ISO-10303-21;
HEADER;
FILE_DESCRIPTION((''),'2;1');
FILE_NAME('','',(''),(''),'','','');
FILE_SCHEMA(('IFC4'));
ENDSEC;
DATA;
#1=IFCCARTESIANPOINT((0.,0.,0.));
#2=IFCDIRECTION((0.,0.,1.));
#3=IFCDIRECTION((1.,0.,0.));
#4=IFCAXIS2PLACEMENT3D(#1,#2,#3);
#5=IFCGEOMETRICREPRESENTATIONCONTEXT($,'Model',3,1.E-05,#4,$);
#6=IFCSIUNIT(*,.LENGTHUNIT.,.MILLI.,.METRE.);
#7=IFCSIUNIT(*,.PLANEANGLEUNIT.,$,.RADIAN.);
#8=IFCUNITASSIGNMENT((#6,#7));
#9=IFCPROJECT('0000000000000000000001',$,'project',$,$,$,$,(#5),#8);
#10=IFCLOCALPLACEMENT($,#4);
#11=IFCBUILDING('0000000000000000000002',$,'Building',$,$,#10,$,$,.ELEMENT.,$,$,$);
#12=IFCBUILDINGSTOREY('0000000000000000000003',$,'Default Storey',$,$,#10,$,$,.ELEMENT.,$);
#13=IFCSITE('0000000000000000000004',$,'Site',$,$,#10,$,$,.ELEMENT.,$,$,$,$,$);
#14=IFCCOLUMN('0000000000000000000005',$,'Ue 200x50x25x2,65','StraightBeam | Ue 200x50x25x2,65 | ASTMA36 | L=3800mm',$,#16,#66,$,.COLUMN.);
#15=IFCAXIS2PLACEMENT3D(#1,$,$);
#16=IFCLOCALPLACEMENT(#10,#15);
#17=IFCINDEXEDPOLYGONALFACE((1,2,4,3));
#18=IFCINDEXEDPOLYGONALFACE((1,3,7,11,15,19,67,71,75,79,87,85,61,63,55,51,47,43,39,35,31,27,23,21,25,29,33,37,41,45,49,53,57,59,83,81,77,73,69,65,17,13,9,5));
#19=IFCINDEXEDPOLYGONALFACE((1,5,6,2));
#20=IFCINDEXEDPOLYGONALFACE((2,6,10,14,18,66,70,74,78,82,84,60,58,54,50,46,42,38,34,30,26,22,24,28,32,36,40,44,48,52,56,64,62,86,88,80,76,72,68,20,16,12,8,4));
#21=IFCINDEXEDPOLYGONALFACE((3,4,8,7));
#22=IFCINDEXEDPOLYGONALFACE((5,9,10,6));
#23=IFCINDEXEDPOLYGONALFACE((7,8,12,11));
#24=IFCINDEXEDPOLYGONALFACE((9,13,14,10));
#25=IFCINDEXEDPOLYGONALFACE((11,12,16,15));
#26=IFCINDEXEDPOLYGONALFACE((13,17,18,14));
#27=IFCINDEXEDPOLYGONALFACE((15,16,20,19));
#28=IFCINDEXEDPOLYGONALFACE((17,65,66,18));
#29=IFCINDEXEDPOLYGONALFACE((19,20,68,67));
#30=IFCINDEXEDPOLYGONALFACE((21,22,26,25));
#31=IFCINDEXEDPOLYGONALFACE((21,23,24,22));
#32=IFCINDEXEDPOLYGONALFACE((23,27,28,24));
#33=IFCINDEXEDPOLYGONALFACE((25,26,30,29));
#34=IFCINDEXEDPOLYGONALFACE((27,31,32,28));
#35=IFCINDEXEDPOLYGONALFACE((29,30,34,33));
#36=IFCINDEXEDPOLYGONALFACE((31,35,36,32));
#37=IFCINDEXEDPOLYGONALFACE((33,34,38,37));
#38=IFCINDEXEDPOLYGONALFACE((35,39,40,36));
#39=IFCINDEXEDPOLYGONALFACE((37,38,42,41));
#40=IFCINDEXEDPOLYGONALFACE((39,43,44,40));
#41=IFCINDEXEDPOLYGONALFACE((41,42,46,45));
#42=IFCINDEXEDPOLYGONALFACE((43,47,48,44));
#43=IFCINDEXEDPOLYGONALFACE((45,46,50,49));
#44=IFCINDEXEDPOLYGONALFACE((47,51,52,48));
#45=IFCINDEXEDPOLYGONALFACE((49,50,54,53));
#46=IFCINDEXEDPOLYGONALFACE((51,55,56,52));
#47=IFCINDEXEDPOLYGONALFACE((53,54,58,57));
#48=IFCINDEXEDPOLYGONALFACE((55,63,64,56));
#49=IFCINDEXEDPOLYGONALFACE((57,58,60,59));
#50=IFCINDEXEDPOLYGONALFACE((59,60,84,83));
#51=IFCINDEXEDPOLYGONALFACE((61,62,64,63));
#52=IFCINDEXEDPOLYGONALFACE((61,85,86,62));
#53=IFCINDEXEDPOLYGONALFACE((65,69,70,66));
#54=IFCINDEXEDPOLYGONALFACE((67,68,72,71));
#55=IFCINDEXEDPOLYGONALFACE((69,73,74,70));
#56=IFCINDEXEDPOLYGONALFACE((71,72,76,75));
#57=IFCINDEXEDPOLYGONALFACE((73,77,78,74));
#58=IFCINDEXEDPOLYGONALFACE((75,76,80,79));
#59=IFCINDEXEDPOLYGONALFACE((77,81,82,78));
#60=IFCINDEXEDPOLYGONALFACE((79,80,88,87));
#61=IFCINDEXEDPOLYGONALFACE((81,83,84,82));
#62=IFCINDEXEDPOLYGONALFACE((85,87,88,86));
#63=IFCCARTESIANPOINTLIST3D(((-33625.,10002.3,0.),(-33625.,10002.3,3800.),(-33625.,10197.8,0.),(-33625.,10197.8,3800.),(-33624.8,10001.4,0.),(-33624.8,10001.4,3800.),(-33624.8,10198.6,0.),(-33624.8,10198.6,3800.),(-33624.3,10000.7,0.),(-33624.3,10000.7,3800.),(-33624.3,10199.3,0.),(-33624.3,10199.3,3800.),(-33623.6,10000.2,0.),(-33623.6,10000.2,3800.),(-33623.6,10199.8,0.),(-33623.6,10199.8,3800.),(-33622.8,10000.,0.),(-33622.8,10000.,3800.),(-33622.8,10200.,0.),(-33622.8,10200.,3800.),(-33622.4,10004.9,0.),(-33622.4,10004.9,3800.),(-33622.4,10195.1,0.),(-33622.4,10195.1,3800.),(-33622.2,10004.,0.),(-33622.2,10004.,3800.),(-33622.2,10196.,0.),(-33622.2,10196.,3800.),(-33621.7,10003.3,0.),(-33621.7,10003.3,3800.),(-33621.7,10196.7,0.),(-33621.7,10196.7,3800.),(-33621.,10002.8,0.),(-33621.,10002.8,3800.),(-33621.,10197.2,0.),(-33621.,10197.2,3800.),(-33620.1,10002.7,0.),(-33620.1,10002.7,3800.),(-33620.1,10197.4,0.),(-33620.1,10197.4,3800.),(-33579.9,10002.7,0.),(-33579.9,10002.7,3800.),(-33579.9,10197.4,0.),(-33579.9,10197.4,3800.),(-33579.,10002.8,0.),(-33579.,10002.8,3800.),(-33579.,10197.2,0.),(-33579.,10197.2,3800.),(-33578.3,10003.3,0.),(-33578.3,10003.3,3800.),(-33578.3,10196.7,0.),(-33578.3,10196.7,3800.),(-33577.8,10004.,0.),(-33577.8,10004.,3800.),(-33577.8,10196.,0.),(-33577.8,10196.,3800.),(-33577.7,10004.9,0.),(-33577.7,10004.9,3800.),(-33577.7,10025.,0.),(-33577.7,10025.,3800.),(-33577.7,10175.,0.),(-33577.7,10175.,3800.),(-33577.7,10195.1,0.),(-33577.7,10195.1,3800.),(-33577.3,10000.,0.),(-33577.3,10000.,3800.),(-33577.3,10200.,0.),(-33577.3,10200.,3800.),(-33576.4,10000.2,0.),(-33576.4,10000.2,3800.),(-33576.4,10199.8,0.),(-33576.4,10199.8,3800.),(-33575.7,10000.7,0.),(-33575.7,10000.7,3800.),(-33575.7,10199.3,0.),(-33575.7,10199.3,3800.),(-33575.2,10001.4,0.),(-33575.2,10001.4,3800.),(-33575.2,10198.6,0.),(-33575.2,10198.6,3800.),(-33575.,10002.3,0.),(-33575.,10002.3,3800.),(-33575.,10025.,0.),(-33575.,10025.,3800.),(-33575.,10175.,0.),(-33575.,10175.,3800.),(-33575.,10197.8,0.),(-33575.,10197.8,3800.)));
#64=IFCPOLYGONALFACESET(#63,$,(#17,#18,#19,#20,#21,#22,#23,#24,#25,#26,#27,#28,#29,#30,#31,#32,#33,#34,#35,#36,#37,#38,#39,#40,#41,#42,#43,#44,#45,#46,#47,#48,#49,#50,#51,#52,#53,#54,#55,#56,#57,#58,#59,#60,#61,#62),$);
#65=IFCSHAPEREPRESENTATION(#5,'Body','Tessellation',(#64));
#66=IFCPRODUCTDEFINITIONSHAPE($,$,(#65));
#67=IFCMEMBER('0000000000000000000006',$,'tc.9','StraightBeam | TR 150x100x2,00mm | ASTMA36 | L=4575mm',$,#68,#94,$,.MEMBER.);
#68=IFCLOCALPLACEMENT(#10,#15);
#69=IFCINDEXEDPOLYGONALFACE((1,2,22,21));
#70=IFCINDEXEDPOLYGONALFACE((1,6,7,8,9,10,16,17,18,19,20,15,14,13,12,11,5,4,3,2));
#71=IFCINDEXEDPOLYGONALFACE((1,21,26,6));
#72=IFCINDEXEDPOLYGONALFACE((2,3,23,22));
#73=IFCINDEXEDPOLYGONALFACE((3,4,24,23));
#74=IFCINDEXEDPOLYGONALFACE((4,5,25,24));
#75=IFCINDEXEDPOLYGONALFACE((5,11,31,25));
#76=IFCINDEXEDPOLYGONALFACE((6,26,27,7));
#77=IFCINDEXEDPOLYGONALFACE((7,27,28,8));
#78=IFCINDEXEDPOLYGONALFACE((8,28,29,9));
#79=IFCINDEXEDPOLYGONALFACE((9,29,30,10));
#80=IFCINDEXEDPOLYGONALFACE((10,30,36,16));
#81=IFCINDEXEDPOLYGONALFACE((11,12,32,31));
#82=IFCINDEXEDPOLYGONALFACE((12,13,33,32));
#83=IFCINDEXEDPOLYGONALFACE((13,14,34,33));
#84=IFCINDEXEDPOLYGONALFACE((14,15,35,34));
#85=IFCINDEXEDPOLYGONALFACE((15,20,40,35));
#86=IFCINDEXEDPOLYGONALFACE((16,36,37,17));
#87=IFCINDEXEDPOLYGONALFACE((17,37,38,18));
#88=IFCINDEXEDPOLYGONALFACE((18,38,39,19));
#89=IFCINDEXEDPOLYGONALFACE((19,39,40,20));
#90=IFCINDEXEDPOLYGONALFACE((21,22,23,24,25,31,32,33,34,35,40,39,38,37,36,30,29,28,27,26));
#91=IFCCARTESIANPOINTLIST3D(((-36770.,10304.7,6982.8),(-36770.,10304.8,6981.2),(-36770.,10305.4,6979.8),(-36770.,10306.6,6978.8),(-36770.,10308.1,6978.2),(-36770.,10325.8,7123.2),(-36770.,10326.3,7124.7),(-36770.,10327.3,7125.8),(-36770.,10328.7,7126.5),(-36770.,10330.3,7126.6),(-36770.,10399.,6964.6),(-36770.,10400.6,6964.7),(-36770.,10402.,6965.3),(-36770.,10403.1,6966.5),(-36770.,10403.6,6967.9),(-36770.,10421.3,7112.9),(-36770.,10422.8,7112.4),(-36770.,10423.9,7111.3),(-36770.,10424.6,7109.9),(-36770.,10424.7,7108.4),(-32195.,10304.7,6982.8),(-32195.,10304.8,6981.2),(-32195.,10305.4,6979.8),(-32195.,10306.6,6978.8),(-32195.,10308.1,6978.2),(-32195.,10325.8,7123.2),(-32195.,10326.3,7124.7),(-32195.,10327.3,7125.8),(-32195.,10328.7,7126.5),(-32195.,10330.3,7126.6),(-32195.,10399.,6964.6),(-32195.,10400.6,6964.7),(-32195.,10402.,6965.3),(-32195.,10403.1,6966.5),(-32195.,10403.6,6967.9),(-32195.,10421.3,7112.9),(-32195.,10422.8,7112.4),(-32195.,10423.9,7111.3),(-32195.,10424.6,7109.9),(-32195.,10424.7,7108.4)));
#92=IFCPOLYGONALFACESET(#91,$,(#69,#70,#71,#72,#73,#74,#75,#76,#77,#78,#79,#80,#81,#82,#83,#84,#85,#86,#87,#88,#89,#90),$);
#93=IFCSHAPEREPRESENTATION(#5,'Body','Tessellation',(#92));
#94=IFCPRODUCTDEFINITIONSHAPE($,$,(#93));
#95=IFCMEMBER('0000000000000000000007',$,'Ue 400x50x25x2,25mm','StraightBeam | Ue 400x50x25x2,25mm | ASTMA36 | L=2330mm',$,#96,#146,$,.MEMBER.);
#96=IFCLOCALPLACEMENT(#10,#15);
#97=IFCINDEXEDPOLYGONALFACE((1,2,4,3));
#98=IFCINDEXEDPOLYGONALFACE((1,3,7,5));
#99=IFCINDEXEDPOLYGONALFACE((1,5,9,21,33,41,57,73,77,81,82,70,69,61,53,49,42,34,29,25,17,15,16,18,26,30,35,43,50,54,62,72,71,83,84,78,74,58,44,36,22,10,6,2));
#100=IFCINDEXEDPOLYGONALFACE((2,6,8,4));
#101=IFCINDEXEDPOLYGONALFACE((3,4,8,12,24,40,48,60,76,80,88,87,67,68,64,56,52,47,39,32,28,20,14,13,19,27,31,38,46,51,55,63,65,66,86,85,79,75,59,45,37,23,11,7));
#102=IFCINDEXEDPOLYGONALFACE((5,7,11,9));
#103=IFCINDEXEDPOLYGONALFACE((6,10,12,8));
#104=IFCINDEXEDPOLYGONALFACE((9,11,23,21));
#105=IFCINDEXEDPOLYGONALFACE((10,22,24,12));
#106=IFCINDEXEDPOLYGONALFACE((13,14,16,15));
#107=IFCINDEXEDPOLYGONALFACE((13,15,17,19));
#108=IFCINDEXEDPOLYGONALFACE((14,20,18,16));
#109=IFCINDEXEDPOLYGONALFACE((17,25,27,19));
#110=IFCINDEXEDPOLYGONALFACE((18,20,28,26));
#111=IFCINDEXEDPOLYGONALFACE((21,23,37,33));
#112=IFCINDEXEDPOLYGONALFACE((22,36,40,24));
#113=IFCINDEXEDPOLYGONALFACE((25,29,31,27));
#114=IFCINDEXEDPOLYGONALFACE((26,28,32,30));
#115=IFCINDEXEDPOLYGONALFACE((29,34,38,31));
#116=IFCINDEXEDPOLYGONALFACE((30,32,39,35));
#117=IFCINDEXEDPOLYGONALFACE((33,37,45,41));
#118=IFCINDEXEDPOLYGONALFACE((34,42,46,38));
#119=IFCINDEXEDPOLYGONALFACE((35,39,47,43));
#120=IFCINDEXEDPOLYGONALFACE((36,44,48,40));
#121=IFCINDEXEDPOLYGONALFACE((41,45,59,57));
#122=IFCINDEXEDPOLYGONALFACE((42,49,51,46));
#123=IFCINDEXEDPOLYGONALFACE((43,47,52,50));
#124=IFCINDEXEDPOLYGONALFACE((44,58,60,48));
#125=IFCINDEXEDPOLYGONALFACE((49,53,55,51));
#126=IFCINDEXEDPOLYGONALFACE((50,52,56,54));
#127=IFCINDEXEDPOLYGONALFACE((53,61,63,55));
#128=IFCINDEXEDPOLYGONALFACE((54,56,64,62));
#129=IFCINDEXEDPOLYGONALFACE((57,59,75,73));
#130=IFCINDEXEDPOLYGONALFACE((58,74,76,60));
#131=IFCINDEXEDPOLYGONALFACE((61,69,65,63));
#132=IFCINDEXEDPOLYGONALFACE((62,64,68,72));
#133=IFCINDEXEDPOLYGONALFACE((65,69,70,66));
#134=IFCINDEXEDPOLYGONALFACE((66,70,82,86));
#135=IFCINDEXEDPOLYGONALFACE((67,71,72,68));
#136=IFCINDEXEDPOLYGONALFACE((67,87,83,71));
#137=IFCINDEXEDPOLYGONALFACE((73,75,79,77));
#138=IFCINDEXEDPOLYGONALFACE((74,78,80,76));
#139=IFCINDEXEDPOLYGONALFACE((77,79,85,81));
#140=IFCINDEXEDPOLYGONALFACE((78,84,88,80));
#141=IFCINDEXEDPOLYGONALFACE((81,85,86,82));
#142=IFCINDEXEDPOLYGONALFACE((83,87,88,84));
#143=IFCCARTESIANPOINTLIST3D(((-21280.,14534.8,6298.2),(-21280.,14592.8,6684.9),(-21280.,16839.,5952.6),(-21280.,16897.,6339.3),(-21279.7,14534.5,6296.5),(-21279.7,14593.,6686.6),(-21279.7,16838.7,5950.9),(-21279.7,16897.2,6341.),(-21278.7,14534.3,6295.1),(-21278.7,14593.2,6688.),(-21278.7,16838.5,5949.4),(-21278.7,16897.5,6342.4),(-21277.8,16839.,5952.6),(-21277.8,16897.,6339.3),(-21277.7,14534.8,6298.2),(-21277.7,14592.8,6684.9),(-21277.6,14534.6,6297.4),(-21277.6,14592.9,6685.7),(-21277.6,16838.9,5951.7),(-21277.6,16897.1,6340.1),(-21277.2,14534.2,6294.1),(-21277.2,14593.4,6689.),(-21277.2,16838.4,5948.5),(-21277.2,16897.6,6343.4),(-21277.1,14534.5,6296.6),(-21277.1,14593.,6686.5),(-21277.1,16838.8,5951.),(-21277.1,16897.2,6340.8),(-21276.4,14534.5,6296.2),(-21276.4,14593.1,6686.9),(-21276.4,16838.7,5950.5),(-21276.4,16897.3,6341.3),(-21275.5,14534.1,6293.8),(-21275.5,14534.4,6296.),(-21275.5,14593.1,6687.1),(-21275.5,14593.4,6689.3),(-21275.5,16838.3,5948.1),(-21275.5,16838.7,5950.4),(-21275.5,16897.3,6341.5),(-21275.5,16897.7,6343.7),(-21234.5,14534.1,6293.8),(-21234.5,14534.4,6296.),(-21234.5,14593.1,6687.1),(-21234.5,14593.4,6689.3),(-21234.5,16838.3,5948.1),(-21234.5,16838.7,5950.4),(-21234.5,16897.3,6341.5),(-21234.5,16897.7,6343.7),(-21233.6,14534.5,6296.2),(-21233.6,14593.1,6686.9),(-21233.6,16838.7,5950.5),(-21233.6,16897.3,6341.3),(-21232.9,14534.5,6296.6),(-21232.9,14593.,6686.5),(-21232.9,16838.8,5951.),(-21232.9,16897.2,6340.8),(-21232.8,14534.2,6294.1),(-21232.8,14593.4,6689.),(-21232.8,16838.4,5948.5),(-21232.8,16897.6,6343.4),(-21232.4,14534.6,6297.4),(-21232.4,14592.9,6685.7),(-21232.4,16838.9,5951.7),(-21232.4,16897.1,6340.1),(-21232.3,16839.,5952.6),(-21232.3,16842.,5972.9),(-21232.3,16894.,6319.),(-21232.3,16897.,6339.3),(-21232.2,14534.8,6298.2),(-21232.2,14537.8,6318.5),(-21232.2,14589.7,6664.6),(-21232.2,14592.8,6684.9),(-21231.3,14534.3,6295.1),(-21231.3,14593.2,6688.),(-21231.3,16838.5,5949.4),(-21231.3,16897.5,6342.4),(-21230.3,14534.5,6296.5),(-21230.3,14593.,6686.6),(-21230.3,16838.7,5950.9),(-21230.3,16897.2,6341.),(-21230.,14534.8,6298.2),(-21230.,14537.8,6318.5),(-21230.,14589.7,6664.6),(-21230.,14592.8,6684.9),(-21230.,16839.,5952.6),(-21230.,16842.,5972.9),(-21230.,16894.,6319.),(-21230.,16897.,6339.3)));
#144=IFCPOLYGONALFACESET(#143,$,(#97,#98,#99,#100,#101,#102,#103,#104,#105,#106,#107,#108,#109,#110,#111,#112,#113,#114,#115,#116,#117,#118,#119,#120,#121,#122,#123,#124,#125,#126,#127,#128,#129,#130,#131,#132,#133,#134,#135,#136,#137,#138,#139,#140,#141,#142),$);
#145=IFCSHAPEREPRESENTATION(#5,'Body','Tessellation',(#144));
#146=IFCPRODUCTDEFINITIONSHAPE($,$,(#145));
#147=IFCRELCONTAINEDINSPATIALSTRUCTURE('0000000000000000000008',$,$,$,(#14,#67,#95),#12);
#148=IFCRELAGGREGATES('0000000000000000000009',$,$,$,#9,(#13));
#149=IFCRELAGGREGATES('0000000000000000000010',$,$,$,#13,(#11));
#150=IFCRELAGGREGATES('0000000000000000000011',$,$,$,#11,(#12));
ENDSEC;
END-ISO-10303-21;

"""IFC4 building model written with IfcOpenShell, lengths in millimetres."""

from ifc_helpers import new_model, si_unit, frame, origin_with_axes, place, context, project, spatial, polyline, outline, extrude, element, save


model = new_model("IFC4")

# Units and contexts
model_context = context("Model", 3, precision=1e-05, world=origin_with_axes())
ifc_project = project(units=[si_unit("LENGTHUNIT", "METRE", prefix="MILLI"), si_unit("PLANEANGLEUNIT", "RADIAN")], contexts=[model_context])

# Site, building, storey
placement = place(None, origin_with_axes())
site = spatial("IfcSite", under=ifc_project, at=placement, Name="Site", CompositionType="ELEMENT")
building = spatial("IfcBuilding", under=site, at=placement, Name="Building", CompositionType="ELEMENT")
storey = spatial("IfcBuildingStorey", under=building, at=placement, Name="Default Storey", CompositionType="ELEMENT")

# Column
column_placement = place(placement, frame((-33600.0, 10100.0, 0.0), z_axis=(0.0, 0.0, -1.0), x_axis=(1.0, 0.0, 0.0)))
element("IfcColumn", 1, at=column_placement, inside=storey, Name="Ue 200x50x25x2,65", Description="StraightBeam | Ue 200x50x25x2,65 | ASTMA36 | L=3800mm", PredefinedType="COLUMN", context=model_context, shape_type="SweptSolid", body=[
    extrude(outline(polyline([(25.0, -75.0), (22.4, -75.0), (22.4, -95.1), (22.2, -96.0), (21.7, -96.7), (21.0, -97.2), (20.1, -97.3), (-20.1, -97.3), (-21.0, -97.2), (-21.7, -96.7), (-22.2, -96.0), (-22.4, -95.1), (-22.4, 95.1), (-22.2, 96.0), (-21.7, 96.7), (-21.0, 97.2), (-20.1, 97.3), (20.1, 97.3), (21.0, 97.2), (21.7, 96.7), (22.2, 96.0), (22.4, 95.1), (22.4, 75.0), (25.0, 75.0), (25.0, 97.8), (24.8, 98.6), (24.3, 99.3), (23.6, 99.8), (22.8, 100.0), (-22.8, 100.0), (-23.6, 99.8), (-24.3, 99.3), (-24.8, 98.6), (-25.0, 97.8), (-25.0, -97.8), (-24.8, -98.6), (-24.3, -99.3), (-23.6, -99.8), (-22.8, -100.0), (22.8, -100.0), (23.6, -99.8), (24.3, -99.3), (24.8, -98.6), (25.0, -97.8), (25.0, -75.0)])), origin_with_axes(), (0.0, 0.0, -1.0), 3800.0),
])

# Members
member_1_placement = place(placement, frame((-32195.0, 10364.7, 7045.6), z_axis=(1.0, 0.0, 0.0), x_axis=(0.0, 0.988936, -0.14834)))
element("IfcMember", 2, at=member_1_placement, inside=storey, Name="tc.9", Description="StraightBeam | TR 150x100x2,00mm | ASTMA36 | L=4575mm", PredefinedType="MEMBER", context=model_context, shape_type="SweptSolid", body=[
    extrude(outline(polyline([(-46.0, -75.0), (46.0, -75.0), (47.5, -74.7), (48.8, -73.8), (49.7, -72.5), (50.0, -71.0), (50.0, 71.0), (49.7, 72.5), (48.8, 73.8), (47.5, 74.7), (46.0, 75.0), (-46.0, 75.0), (-47.5, 74.7), (-48.8, 73.8), (-49.7, 72.5), (-50.0, 71.0), (-50.0, -71.0), (-49.7, -72.5), (-48.8, -73.8), (-47.5, -74.7), (-46.0, -75.0)])), origin_with_axes(), (0.0, 0.0, -1.0), 4575.0),
])
member_2_placement = place(placement, frame((-21255.0, 16868.0, 6145.9), z_axis=(0.0, -0.988936, 0.14834), x_axis=(1.0, 0.0, 0.0)))
element("IfcMember", 3, at=member_2_placement, inside=storey, Name="Ue 400x50x25x2,25mm", Description="StraightBeam | Ue 400x50x25x2,25mm | ASTMA36 | L=2330mm", PredefinedType="MEMBER", context=model_context, shape_type="SweptSolid", body=[
    extrude(outline(polyline([(25.0, -175.0), (22.8, -175.0), (22.8, -195.5), (22.6, -196.4), (22.1, -197.1), (21.4, -197.6), (20.5, -197.8), (-20.5, -197.8), (-21.4, -197.6), (-22.1, -197.1), (-22.6, -196.4), (-22.8, -195.5), (-22.8, 195.5), (-22.6, 196.4), (-22.1, 197.1), (-21.4, 197.6), (-20.5, 197.8), (20.5, 197.8), (21.4, 197.6), (22.1, 197.1), (22.6, 196.4), (22.8, 195.5), (22.8, 175.0), (25.0, 175.0), (25.0, 195.5), (24.7, 197.2), (23.7, 198.7), (22.2, 199.7), (20.5, 200.0), (-20.5, 200.0), (-22.2, 199.7), (-23.7, 198.7), (-24.7, 197.2), (-25.0, 195.5), (-25.0, -195.5), (-24.7, -197.2), (-23.7, -198.7), (-22.2, -199.7), (-20.5, -200.0), (20.5, -200.0), (22.2, -199.7), (23.7, -198.7), (24.7, -197.2), (25.0, -195.5), (25.0, -175.0)])), origin_with_axes(), (0.0, 0.0, 1.0), 2330.0),
])

save(model, "model.ifc")
